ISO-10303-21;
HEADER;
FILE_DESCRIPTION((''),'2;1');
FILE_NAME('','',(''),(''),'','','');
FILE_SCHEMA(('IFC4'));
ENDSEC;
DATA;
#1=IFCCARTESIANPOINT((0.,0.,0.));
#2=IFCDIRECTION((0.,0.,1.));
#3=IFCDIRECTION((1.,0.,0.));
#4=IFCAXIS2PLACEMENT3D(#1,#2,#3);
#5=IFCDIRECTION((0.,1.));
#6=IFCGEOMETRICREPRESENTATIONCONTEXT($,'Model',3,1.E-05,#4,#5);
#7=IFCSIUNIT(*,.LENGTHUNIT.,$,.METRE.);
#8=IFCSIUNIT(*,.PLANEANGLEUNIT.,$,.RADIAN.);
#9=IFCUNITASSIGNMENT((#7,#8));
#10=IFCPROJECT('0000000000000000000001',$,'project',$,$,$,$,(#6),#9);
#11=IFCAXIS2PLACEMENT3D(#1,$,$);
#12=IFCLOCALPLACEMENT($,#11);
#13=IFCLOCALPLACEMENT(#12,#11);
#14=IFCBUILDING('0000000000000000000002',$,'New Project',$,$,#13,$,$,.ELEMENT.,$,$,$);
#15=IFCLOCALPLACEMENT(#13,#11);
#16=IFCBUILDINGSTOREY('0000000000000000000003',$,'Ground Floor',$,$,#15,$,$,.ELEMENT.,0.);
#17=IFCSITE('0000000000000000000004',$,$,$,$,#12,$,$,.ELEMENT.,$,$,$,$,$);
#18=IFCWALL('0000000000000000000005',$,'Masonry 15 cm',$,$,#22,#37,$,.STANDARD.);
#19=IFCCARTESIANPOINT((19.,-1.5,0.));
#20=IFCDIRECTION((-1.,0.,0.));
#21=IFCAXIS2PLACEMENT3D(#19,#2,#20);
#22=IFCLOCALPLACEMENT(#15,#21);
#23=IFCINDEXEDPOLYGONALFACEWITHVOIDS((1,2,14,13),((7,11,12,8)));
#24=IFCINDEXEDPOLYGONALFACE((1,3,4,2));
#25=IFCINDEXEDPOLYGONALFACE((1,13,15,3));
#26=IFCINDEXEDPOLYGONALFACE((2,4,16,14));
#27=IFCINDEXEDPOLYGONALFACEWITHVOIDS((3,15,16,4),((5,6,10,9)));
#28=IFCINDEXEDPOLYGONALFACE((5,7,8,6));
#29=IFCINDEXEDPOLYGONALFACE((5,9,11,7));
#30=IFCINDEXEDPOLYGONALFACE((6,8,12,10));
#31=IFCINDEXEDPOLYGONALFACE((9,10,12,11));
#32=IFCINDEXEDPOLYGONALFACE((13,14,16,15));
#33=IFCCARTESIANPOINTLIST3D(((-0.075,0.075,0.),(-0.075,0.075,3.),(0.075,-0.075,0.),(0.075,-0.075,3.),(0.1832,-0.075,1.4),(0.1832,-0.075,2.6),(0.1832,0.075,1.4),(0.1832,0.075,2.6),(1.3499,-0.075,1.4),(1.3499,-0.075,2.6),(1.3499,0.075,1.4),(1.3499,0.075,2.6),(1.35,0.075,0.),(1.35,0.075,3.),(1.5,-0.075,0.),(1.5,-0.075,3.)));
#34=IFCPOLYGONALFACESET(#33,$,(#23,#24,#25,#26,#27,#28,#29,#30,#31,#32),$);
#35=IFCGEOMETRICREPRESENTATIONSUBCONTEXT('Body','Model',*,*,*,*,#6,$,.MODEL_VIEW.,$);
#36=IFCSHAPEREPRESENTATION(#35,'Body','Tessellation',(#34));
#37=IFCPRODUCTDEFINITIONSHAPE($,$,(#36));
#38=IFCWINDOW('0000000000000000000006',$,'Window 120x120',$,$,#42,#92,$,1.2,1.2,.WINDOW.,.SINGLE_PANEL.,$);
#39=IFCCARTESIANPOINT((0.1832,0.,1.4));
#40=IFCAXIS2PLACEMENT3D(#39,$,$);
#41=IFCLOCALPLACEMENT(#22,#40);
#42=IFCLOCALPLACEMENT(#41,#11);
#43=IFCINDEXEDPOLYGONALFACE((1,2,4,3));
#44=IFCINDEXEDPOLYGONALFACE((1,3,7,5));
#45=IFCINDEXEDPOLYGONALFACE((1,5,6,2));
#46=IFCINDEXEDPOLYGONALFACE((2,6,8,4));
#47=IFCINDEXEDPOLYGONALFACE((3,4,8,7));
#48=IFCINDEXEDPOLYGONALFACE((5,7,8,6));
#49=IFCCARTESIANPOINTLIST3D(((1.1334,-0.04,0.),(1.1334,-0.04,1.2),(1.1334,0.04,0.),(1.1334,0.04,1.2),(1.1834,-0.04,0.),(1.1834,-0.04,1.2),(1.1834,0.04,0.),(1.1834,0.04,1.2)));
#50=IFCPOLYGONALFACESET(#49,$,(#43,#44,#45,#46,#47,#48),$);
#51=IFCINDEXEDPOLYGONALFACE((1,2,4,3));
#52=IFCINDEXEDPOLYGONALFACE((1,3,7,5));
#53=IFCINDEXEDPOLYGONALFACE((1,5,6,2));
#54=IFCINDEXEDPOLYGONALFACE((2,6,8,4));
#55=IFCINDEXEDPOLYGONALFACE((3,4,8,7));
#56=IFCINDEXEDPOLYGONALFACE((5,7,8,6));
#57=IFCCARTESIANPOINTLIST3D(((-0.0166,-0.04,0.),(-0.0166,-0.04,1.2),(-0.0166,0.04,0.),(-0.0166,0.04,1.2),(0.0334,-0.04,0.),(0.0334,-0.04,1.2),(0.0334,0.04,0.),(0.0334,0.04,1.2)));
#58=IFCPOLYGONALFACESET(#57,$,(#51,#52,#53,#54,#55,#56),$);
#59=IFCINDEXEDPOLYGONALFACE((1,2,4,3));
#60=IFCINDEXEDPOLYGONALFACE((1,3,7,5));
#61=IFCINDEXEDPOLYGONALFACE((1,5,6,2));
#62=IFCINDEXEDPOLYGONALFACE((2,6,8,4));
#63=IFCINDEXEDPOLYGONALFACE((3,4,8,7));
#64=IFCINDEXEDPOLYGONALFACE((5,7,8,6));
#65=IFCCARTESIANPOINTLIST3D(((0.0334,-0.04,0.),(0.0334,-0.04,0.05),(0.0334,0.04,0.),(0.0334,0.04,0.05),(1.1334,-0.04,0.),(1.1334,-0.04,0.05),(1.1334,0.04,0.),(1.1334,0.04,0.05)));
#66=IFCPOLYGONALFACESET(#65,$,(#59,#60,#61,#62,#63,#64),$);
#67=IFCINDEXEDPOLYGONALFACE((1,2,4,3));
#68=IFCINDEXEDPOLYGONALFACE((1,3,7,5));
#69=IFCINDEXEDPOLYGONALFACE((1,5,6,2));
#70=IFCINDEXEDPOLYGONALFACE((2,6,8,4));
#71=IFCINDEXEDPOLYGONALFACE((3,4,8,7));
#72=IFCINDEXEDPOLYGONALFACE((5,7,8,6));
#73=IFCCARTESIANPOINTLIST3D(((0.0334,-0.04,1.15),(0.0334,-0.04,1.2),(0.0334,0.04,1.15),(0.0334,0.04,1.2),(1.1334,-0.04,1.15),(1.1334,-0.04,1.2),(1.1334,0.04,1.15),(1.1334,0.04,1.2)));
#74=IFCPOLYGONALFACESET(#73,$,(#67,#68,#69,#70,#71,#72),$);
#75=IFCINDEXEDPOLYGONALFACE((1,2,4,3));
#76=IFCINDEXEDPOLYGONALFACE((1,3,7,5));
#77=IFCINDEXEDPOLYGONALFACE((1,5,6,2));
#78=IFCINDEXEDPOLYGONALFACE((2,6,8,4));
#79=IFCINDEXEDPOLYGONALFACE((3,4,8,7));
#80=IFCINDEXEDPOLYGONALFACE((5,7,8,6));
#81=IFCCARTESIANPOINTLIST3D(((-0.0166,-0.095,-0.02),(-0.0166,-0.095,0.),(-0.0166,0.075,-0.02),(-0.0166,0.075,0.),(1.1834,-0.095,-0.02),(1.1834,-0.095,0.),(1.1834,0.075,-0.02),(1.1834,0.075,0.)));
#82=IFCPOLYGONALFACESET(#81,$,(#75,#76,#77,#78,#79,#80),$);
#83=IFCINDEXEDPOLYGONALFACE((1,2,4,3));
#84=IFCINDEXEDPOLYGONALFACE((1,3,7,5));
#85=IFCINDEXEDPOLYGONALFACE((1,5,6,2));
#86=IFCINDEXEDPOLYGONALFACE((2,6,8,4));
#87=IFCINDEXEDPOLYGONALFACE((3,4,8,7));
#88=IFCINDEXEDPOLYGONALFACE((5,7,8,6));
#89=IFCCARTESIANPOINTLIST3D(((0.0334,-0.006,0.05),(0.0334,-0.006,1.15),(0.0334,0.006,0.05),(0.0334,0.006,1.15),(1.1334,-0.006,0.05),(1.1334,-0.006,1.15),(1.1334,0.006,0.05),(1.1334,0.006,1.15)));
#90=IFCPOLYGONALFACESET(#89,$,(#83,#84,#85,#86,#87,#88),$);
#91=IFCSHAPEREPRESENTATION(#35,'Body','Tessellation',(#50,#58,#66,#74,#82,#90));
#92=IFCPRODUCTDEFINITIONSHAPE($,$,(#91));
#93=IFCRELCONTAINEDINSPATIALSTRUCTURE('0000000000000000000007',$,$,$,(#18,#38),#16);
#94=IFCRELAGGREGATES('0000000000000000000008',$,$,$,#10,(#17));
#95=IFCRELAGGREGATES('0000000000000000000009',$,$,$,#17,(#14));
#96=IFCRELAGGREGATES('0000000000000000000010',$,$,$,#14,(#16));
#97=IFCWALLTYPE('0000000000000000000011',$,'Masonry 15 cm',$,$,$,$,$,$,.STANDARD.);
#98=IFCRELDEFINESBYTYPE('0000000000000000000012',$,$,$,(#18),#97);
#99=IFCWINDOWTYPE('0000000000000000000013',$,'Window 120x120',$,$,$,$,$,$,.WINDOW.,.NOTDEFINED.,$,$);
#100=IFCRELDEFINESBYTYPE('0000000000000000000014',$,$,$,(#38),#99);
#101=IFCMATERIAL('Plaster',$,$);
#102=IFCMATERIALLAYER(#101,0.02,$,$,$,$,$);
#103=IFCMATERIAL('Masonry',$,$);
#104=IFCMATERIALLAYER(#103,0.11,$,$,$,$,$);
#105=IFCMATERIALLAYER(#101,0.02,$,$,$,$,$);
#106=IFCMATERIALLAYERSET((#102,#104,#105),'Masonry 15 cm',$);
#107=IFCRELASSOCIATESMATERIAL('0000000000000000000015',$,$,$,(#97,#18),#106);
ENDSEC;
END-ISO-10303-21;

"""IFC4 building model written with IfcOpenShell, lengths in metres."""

from ifc_helpers import new_model, si_unit, direction, frame, frame_2d, origin, origin_with_axes, place, context, subcontext, project, spatial, polyline, rectangle, outline, extrude, material, layer, layer_set, layer_usage, type_object, element, fill, save


model = new_model("IFC4")

# Units and contexts
model_context = context("Model", 3, precision=1e-05, world=origin_with_axes(), true_north=direction((0.0, 1.0)))
body_context = subcontext(model_context, "Body", "Model", "MODEL_VIEW")
ifc_project = project(units=[si_unit("LENGTHUNIT", "METRE"), si_unit("PLANEANGLEUNIT", "RADIAN")], contexts=[model_context])

# Site, building, storey
site_placement = place(None, origin())
site = spatial("IfcSite", under=ifc_project, at=site_placement, CompositionType="ELEMENT")
building_placement = place(site_placement, origin())
building = spatial("IfcBuilding", under=site, at=building_placement, Name="New Project", CompositionType="ELEMENT")
storey_placement = place(building_placement, origin())
storey = spatial("IfcBuildingStorey", under=building, at=storey_placement, Name="Ground Floor", CompositionType="ELEMENT", Elevation=0.0)

# Shared definitions
ifc_material_1 = material(Name="Plaster")
ifc_layer_1 = layer(ifc_material_1, 0.02)
ifc_material_2 = material(Name="Masonry")
ifc_layer_2 = layer(ifc_material_2, 0.11)
ifc_layer_3 = layer(ifc_material_1, 0.02)
ifc_layer_set_1 = layer_set([ifc_layer_1, ifc_layer_2, ifc_layer_3], Name="Masonry 15 cm")
ifc_layer_usage_1 = layer_usage(ifc_layer_set_1, "AXIS2", "NEGATIVE", 0.075)
wall_type_1 = type_object("IfcWallType", Name="Masonry 15 cm", PredefinedType="STANDARD", material=ifc_layer_set_1)
window_type_1 = type_object("IfcWindowType", Name="Window 120x120", PartitioningType="NOTDEFINED", PredefinedType="WINDOW")

# Wall, opening, window
wall_1_placement = place(storey_placement, frame((19.0, -1.5, 0.0), z_axis=(0.0, 0.0, 1.0), x_axis=(-1.0, 0.0, 0.0)))
wall_1 = element("IfcWall", 1, at=wall_1_placement, inside=storey, type_object=wall_type_1, material=ifc_layer_usage_1, Name="Masonry 15 cm", PredefinedType="STANDARD", context=body_context, shape_type="SweptSolid", body=[
    extrude(outline(polyline([(0.075, -0.075), (1.5, -0.075), (1.35, 0.075), (-0.075, 0.075), (0.075, -0.075)])), origin(), (0.0, 0.0, 1.0), 3.0),
])
opening_1_placement = place(wall_1_placement, frame((0.1832, 0.0, 1.4)))
opening_1 = element("IfcOpeningElement", 2, at=opening_1_placement, cuts=wall_1, PredefinedType="OPENING", context=body_context, shape_type="SweptSolid", body=[
    extrude(rectangle(XDim=1.1667, YDim=0.25, at=frame_2d((0.5834, 0.0))), origin(), (0.0, 0.0, 1.0), 1.2),
])
window_1_placement = place(opening_1_placement, origin())
window_1 = element("IfcWindow", 3, at=window_1_placement, inside=storey, type_object=window_type_1, Name="Window 120x120", OverallHeight=1.2, OverallWidth=1.2, PartitioningType="SINGLE_PANEL", PredefinedType="WINDOW", context=body_context, shape_type="SweptSolid", body=[
    extrude(outline(polyline([(1.1834, 0.04), (1.1334, 0.04), (1.1334, -0.04), (1.1834, -0.04), (1.1834, 0.04)])), origin(), (0.0, 0.0, 1.0), 1.2),
    extrude(outline(polyline([(0.0334, 0.04), (-0.0166, 0.04), (-0.0166, -0.04), (0.0334, -0.04), (0.0334, 0.04)])), origin(), (0.0, 0.0, 1.0), 1.2),
    extrude(outline(polyline([(1.1334, 0.04), (0.0334, 0.04), (0.0334, -0.04), (1.1334, -0.04), (1.1334, 0.04)])), origin(), (0.0, 0.0, 1.0), 0.05),
    extrude(outline(polyline([(1.1334, 0.04), (0.0334, 0.04), (0.0334, -0.04), (1.1334, -0.04), (1.1334, 0.04)])), frame((0.0, 0.0, 1.15)), (0.0, 0.0, 1.0), 0.05),
    extrude(outline(polyline([(1.1834, 0.075), (-0.0166, 0.075), (-0.0166, -0.095), (1.1834, -0.095), (1.1834, 0.075)])), frame((0.0, 0.0, -0.02)), (0.0, 0.0, 1.0), 0.02),
    extrude(outline(polyline([(1.1334, 0.006), (0.0334, 0.006), (0.0334, -0.006), (1.1334, -0.006), (1.1334, 0.006)])), frame((0.0, 0.0, 0.05)), (0.0, 0.0, 1.0), 1.1),
])
fill(opening_1, window_1)

save(model, "model.ifc")
